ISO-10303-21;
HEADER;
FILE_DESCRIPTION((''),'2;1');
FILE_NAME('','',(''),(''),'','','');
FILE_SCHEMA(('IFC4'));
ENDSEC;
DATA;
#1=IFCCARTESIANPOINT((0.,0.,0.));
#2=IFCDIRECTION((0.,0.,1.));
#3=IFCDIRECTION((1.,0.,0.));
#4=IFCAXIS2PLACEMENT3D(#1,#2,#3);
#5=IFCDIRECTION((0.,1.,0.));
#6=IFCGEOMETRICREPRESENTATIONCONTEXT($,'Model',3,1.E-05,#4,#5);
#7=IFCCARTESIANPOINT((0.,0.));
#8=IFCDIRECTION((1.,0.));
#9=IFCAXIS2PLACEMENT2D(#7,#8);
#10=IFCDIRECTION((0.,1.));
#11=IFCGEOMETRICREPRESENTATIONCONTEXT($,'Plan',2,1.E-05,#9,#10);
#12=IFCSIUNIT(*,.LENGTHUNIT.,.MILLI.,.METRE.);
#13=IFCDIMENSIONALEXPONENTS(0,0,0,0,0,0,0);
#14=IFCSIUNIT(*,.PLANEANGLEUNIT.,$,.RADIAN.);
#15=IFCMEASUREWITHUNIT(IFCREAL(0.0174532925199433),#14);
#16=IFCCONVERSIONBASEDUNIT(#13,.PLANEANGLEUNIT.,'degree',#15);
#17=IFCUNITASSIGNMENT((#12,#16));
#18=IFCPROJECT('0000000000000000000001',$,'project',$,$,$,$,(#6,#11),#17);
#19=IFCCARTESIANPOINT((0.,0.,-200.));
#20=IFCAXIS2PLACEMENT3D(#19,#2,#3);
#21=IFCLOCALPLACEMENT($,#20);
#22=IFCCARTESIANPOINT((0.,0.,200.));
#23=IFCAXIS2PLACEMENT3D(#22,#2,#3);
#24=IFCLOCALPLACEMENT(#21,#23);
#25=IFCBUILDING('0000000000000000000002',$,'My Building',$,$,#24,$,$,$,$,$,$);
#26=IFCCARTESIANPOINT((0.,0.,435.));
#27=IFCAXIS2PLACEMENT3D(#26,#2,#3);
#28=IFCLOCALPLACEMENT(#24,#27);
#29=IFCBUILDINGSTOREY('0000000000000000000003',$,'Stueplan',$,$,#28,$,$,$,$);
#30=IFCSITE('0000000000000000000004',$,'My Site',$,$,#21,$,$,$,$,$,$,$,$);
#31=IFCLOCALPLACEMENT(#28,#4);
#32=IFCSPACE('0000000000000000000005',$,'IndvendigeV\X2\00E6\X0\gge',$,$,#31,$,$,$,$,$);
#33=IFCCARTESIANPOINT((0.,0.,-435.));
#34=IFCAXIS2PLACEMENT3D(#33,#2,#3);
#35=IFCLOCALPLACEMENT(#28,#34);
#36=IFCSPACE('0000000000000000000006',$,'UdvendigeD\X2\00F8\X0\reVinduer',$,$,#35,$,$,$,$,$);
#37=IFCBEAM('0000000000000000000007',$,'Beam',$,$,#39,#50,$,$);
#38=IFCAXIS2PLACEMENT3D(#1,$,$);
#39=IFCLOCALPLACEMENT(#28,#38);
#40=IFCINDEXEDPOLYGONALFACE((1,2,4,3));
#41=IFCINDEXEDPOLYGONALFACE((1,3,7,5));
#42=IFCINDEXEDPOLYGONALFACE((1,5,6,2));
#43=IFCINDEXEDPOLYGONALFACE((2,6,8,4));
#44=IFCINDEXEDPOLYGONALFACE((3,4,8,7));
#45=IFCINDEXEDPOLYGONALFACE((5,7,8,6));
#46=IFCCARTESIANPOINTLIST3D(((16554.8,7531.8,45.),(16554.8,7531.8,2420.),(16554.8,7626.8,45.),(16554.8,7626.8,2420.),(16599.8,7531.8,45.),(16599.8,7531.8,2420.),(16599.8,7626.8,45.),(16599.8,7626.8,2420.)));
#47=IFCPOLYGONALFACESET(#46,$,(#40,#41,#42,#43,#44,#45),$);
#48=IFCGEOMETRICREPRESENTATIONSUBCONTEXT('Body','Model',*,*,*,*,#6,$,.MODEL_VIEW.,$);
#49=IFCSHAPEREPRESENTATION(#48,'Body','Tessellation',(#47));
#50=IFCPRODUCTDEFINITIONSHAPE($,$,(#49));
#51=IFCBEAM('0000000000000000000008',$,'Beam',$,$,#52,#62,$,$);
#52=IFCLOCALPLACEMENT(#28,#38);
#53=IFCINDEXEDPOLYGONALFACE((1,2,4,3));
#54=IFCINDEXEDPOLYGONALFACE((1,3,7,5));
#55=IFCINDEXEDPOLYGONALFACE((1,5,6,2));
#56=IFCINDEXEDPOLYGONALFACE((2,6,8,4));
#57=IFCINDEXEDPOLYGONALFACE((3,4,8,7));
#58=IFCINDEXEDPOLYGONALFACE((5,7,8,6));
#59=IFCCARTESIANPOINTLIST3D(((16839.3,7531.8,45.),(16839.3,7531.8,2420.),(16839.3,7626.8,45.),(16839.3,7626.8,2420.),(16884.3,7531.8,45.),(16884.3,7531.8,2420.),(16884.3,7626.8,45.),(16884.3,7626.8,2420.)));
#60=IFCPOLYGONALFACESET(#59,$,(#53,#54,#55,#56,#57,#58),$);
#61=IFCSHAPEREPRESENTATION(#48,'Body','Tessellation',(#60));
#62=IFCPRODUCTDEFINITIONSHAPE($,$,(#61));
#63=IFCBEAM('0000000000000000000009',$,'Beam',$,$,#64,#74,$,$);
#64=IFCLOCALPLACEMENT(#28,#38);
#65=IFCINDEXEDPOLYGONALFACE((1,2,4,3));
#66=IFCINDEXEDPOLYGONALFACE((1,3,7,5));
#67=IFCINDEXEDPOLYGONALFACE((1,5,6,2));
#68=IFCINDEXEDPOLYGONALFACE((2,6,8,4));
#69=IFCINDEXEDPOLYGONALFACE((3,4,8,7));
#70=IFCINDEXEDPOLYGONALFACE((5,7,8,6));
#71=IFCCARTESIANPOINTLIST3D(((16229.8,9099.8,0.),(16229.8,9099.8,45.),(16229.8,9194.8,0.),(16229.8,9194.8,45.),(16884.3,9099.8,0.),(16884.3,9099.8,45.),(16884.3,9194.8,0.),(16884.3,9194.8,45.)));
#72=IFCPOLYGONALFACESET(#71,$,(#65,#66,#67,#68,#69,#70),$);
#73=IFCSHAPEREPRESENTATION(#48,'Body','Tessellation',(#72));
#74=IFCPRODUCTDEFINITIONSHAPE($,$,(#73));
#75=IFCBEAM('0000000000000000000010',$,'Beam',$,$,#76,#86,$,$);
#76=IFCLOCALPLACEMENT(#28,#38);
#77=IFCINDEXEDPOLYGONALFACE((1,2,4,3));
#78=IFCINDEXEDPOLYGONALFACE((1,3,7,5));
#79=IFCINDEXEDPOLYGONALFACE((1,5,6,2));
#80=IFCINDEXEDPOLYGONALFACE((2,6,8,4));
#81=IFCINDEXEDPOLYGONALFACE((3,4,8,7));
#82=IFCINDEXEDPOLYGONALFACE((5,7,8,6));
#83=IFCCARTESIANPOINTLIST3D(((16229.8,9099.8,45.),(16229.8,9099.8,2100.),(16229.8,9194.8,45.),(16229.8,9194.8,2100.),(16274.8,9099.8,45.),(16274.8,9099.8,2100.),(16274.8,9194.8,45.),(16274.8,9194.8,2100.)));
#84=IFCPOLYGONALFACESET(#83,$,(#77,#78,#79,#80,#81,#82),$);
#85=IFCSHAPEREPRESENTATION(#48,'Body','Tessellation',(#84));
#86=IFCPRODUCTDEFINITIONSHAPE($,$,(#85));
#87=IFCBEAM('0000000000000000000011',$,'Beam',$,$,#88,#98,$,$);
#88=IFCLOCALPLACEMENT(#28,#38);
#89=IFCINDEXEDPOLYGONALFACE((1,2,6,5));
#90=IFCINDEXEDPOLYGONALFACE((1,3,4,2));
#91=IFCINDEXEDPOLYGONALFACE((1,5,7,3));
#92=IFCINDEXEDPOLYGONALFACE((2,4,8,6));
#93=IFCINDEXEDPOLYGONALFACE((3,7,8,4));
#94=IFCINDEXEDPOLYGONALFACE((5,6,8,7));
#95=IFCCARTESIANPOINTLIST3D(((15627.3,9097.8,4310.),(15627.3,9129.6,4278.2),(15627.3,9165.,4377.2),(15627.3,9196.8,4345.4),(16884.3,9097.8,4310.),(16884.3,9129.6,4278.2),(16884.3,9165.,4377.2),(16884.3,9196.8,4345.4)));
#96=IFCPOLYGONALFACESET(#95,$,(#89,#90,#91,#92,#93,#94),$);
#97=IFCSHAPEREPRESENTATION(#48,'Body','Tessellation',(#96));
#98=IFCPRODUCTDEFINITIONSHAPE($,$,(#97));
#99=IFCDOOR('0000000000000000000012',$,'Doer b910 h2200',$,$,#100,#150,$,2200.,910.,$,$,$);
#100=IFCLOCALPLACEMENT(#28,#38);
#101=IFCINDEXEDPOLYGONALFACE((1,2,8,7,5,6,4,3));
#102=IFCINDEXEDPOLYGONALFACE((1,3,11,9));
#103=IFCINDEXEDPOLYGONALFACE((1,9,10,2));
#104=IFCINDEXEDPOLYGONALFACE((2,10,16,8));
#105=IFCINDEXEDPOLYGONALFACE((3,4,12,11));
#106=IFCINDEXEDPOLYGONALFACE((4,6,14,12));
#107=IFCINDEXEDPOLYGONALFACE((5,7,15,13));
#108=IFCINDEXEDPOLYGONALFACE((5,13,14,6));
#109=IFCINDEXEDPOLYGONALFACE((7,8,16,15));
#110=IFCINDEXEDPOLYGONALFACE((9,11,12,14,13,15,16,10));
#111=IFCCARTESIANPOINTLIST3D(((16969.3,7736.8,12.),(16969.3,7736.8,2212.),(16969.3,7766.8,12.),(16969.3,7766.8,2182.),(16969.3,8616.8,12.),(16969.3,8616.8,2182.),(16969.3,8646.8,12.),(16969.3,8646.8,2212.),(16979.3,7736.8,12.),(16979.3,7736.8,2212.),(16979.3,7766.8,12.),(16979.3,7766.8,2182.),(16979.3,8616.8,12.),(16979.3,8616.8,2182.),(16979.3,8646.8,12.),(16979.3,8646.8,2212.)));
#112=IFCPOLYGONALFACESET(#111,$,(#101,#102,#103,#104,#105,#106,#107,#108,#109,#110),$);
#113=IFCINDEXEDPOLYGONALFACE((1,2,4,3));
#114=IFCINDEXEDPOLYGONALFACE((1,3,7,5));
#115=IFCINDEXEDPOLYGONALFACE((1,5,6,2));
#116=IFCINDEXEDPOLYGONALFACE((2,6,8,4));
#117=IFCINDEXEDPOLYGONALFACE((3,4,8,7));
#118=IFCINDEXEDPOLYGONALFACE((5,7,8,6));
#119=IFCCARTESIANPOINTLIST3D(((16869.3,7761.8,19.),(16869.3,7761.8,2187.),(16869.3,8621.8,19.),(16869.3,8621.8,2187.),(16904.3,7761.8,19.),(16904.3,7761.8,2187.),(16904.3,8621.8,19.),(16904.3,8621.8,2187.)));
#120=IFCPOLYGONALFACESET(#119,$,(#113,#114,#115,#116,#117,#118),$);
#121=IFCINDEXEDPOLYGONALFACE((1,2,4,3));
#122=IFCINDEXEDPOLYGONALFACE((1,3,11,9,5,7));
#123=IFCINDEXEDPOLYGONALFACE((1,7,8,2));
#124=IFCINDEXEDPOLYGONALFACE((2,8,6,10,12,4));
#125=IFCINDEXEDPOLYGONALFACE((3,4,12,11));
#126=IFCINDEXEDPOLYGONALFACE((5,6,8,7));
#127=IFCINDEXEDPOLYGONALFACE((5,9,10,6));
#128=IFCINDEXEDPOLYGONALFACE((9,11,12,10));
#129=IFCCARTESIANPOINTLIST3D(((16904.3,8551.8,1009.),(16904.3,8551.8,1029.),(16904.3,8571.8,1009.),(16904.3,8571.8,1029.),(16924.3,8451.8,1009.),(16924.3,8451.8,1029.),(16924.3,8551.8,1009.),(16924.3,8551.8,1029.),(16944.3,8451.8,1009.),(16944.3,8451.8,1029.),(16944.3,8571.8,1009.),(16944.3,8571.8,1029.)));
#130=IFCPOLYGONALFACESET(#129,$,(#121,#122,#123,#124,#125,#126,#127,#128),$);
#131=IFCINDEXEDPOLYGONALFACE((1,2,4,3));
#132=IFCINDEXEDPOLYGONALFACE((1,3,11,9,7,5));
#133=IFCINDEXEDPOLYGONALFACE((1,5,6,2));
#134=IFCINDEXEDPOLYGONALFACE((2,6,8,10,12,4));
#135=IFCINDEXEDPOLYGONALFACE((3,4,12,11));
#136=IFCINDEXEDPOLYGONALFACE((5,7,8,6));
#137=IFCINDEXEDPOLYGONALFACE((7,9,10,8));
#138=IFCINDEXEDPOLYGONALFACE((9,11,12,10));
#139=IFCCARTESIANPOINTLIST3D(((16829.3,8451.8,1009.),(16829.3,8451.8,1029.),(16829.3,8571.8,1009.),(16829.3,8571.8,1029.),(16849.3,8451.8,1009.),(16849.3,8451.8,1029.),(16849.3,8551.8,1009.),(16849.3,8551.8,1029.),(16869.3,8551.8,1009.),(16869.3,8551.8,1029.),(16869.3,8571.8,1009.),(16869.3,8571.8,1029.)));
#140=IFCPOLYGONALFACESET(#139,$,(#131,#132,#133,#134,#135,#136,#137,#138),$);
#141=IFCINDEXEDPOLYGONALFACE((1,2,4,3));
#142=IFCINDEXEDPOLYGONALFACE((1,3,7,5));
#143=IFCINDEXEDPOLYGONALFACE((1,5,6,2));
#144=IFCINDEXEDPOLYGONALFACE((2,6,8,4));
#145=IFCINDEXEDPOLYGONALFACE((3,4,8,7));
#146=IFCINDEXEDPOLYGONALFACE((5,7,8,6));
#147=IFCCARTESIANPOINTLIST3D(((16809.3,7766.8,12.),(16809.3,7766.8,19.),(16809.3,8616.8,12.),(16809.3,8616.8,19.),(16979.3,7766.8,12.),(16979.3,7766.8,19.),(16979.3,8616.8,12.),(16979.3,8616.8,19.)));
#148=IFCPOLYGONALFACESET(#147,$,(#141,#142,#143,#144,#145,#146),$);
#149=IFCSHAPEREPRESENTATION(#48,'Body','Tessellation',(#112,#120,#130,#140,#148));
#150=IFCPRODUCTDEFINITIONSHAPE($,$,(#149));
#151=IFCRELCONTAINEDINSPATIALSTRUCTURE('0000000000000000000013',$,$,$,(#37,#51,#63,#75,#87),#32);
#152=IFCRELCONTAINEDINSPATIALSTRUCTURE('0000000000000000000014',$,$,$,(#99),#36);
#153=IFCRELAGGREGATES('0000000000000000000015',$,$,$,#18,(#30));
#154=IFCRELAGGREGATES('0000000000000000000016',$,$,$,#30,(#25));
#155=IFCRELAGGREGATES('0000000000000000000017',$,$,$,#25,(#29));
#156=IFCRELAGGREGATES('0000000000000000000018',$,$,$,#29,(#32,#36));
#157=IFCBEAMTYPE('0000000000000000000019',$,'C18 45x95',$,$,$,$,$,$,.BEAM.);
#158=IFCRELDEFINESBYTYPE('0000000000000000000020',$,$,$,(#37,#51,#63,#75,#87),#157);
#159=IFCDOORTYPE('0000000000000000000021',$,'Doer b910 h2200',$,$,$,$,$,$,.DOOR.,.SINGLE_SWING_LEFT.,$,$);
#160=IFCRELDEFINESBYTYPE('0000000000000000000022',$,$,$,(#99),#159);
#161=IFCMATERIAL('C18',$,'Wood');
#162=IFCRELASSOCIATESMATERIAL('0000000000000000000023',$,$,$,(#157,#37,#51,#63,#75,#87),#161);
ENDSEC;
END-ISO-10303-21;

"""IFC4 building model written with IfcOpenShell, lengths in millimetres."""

from ifc_helpers import new_model, entity, si_unit, converted_unit, direction, frame, origin_with_axes, origin_2d_with_axis, place, context, subcontext, project, spatial, line, indexed_curve, rectangle, outline, extrude, shape, source, transform, mapped, material, material_profile, profile_set, profile_usage, type_object, type_shapes, element, save


model = new_model("IFC4")

# Units and contexts
model_context = context("Model", 3, precision=1e-05, world=origin_with_axes(), true_north=direction((0.0, 1.0, 0.0)))
plan_context = context("Plan", 2, precision=1e-05, world=origin_2d_with_axis(), true_north=direction((0.0, 1.0)))
body_context_1 = subcontext(model_context, "Body", "Model", "MODEL_VIEW")
body_context_2 = subcontext(plan_context, "Body", "Plan", "PLAN_VIEW")
ifc_project = project(units=[si_unit("LENGTHUNIT", "METRE", prefix="MILLI"), converted_unit("PLANEANGLEUNIT", "degree", entity("IfcReal", 0.0174532925199433), si_unit("PLANEANGLEUNIT", "RADIAN"), dimensions=[0, 0, 0, 0, 0, 0, 0])], contexts=[model_context, plan_context])

# Site, building, storey
site_placement = place(None, frame((0.0, 0.0, -200.0), z_axis=(0.0, 0.0, 1.0), x_axis=(1.0, 0.0, 0.0)))
site = spatial("IfcSite", under=ifc_project, at=site_placement, Name="My Site")
building_placement = place(site_placement, frame((0.0, 0.0, 200.0), z_axis=(0.0, 0.0, 1.0), x_axis=(1.0, 0.0, 0.0)))
building = spatial("IfcBuilding", under=site, at=building_placement, Name="My Building")
storey_placement = place(building_placement, frame((0.0, 0.0, 435.0), z_axis=(0.0, 0.0, 1.0), x_axis=(1.0, 0.0, 0.0)))
storey = spatial("IfcBuildingStorey", under=building, at=storey_placement, Name="Stueplan")

# Shared definitions
ifc_material = material(Name="C18", Category="Wood")

# Shared definitions
space_1_placement = place(storey_placement, frame((0.0, 0.0, 0.0), z_axis=(0.0, 0.0, 1.0), x_axis=(1.0, 0.0, 0.0)))
space_1 = spatial("IfcSpace", under=storey, at=space_1_placement, Name="IndvendigeVægge")

# Beams
ifc_material_profile_1 = material_profile(ifc_material, rectangle(XDim=45.0, YDim=95.0))
ifc_profile_set_1 = profile_set([ifc_material_profile_1], Name="woodStructural")
beam_type_1 = type_object("IfcBeamType", Name="C18 45x95", PredefinedType="BEAM", material=ifc_profile_set_1)
ifc_profile_usage_1 = profile_usage(ifc_profile_set_1)
beam_1_placement = place(space_1_placement, frame((16577.3, 7579.3, 45.0), z_axis=(0.0, 0.0, 1.0), x_axis=(1.0, 0.0, 0.0)))
element("IfcBeam", 1, at=beam_1_placement, inside=space_1, type_object=beam_type_1, material=ifc_profile_usage_1, Name="Beam", context=body_context_1, shape_type="SweptSolid", body=[
    extrude(rectangle(XDim=45.0, YDim=95.0), origin_with_axes(), (0.0, 0.0, 1.0), 2375.0),
])
ifc_profile_usage_2 = profile_usage(ifc_profile_set_1)
beam_2_placement = place(space_1_placement, frame((16861.8, 7579.3, 45.0), z_axis=(0.0, 0.0, 1.0), x_axis=(1.0, 0.0, 0.0)))
element("IfcBeam", 2, at=beam_2_placement, inside=space_1, type_object=beam_type_1, material=ifc_profile_usage_2, Name="Beam", context=body_context_1, shape_type="SweptSolid", body=[
    extrude(rectangle(XDim=45.0, YDim=95.0), origin_with_axes(), (0.0, 0.0, 1.0), 2375.0),
])
ifc_profile_usage_3 = profile_usage(ifc_profile_set_1, cardinal=5)
beam_3_placement = place(space_1_placement, frame((16229.8, 9147.3, 22.5), z_axis=(1.0, 0.0, 0.0), x_axis=(0.0, 0.0, 1.0)))
element("IfcBeam", 3, at=beam_3_placement, inside=space_1, type_object=beam_type_1, material=ifc_profile_usage_3, Name="Beam", context=body_context_1, shape_type="SweptSolid", body=[
    extrude(rectangle(XDim=45.0, YDim=95.0), origin_with_axes(), (0.0, 0.0, 1.0), 654.5),
])
ifc_profile_usage_4 = profile_usage(ifc_profile_set_1)
beam_4_placement = place(space_1_placement, frame((16252.3, 9147.3, 45.0), z_axis=(0.0, 0.0, 1.0), x_axis=(1.0, 0.0, 0.0)))
element("IfcBeam", 4, at=beam_4_placement, inside=space_1, type_object=beam_type_1, material=ifc_profile_usage_4, Name="Beam", context=body_context_1, shape_type="SweptSolid", body=[
    extrude(rectangle(XDim=45.0, YDim=95.0), origin_with_axes(), (0.0, 0.0, 1.0), 2055.0),
])
ifc_profile_usage_5 = profile_usage(ifc_profile_set_1, cardinal=5)
beam_5_placement = place(space_1_placement, frame((15627.3, 9147.3, 4327.7), z_axis=(1.0, -0.000001, 0.0), x_axis=(0.0, -0.707107, 0.707107)))
element("IfcBeam", 5, at=beam_5_placement, inside=space_1, type_object=beam_type_1, material=ifc_profile_usage_5, Name="Beam", context=body_context_1, shape_type="SweptSolid", body=[
    extrude(rectangle(XDim=45.0, YDim=95.0), origin_with_axes(), (0.0, 0.0, 1.0), 1257.0),
])

# Shared definitions
space_2_placement = place(storey_placement, frame((0.0, 0.0, -435.0), z_axis=(0.0, 0.0, 1.0), x_axis=(1.0, 0.0, 0.0)))
space_2 = spatial("IfcSpace", under=storey, at=space_2_placement, Name="UdvendigeDøreVinduer")

# Door
door_type_1 = type_object("IfcDoorType", Name="Doer b910 h2200", OperationType="SINGLE_SWING_LEFT", PredefinedType="DOOR")
shared_shape_1 = source(origin_with_axes(), body_context_1, "Body", "SweptSolid", [
    extrude(outline(indexed_curve([(0.0, 0.0), (0.0, 2200.0), (910.0, 2200.0), (910.0, 0.0), (880.0, 0.0), (880.0, 2170.0), (30.0, 2170.0), (30.0, 0.0)], segments=[line(1, 2, 3, 4, 5, 6, 7, 8, 1)])), frame((0.0, 0.0, 0.0), z_axis=(0.0, -1.0, 0.0), x_axis=(1.0, 0.0, 0.0)), (0.0, 0.0, -1.0), 10.0),
    extrude(outline(indexed_curve([(0.0, 0.0), (860.0, 0.0), (860.0, 35.0), (0.0, 35.0)], segments=[line(1, 2, 3, 4, 1)])), frame((25.0, 75.0, 7.0), z_axis=(0.0, 0.0, 1.0), x_axis=(1.0, 0.0, 0.0)), (0.0, 0.0, 1.0), 2168.0),
    extrude(outline(indexed_curve([(0.0, 0.0), (0.0, -40.0), (-120.0, -40.0), (-120.0, -20.0), (-20.0, -20.0), (-20.0, 0.0)], segments=[line(1, 2, 3, 4, 5, 6, 1)])), frame((835.0, 75.0, 997.0), z_axis=(0.0, 0.0, 1.0), x_axis=(1.0, 0.0, 0.0)), (0.0, 0.0, 1.0), 20.0),
    extrude(outline(indexed_curve([(0.0, 0.0), (0.0, 40.0), (-120.0, 40.0), (-120.0, 20.0), (-20.0, 20.0), (-20.0, 0.0)], segments=[line(1, 2, 3, 4, 5, 6, 1)])), frame((835.0, 110.0, 997.0), z_axis=(0.0, 0.0, 1.0), x_axis=(1.0, 0.0, 0.0)), (0.0, 0.0, 1.0), 20.0),
    extrude(outline(indexed_curve([(0.0, 0.0), (850.0, 0.0), (850.0, 170.0), (0.0, 170.0)], segments=[line(1, 2, 3, 4, 1)])), frame((30.0, 0.0, 0.0), z_axis=(0.0, 0.0, 1.0), x_axis=(1.0, 0.0, 0.0)), (0.0, 0.0, 1.0), 7.0),
])
shared_shape_2 = source(origin_with_axes(), body_context_2, "Body", "Curve2D", [
    entity("IfcIndexedPolyCurve", entity("IfcCartesianPointList2D", [[0.0, 0.0], [30.0, 0.0], [30.0, 10.0], [0.0, 10.0]]), [entity("IfcLineIndex", [1, 2, 3, 4, 1])]),
    entity("IfcIndexedPolyCurve", entity("IfcCartesianPointList2D", [[910.0, 0.0], [880.0, 0.0], [880.0, 10.0], [910.0, 10.0]]), [entity("IfcLineIndex", [1, 2, 3, 4, 1])]),
    entity("IfcTrimmedCurve", entity("IfcEllipse", entity("IfcAxis2Placement2D", entity("IfcCartesianPoint", [60.0, 10.0]), entity("IfcDirection", [1.0, 0.0])), 825.0, 860.0), [entity("IfcCartesianPoint", [885.0, 10.0])], [entity("IfcCartesianPoint", [60.0, 870.0])], True, "CARTESIAN"),
    entity("IfcIndexedPolyCurve", entity("IfcCartesianPointList2D", [[25.0, 10.0], [60.0, 10.0], [60.0, 870.0], [25.0, 870.0]]), [entity("IfcLineIndex", [1, 2, 3, 4, 1])]),
])
type_shapes(door_type_1, [shared_shape_1, shared_shape_2])
door_1_placement = place(space_2_placement, frame((16979.3, 7736.8, 447.0), z_axis=(0.0, 0.0, 1.0), x_axis=(0.0, 1.0, 0.0)))
element("IfcDoor", 6, at=door_1_placement, inside=space_2, type_object=door_type_1, Name="Doer b910 h2200", OverallHeight=2200.0, OverallWidth=910.0, shapes=[
    shape(body_context_1, "Body", "MappedRepresentation", [mapped(shared_shape_1, transform((0.0, 0.0, 0.0), x_axis=(1.0, 0.0, 0.0), y_axis=(0.0, 1.0, 0.0), z_axis=(0.0, 0.0, 1.0), scale=1.0))]),
    shape(body_context_2, "Body", "MappedRepresentation", [mapped(shared_shape_2, transform((0.0, 0.0, 0.0), x_axis=(1.0, 0.0, 0.0), y_axis=(0.0, 1.0, 0.0), z_axis=(0.0, 0.0, 1.0), scale=1.0))]),
])

save(model, "model.ifc")
